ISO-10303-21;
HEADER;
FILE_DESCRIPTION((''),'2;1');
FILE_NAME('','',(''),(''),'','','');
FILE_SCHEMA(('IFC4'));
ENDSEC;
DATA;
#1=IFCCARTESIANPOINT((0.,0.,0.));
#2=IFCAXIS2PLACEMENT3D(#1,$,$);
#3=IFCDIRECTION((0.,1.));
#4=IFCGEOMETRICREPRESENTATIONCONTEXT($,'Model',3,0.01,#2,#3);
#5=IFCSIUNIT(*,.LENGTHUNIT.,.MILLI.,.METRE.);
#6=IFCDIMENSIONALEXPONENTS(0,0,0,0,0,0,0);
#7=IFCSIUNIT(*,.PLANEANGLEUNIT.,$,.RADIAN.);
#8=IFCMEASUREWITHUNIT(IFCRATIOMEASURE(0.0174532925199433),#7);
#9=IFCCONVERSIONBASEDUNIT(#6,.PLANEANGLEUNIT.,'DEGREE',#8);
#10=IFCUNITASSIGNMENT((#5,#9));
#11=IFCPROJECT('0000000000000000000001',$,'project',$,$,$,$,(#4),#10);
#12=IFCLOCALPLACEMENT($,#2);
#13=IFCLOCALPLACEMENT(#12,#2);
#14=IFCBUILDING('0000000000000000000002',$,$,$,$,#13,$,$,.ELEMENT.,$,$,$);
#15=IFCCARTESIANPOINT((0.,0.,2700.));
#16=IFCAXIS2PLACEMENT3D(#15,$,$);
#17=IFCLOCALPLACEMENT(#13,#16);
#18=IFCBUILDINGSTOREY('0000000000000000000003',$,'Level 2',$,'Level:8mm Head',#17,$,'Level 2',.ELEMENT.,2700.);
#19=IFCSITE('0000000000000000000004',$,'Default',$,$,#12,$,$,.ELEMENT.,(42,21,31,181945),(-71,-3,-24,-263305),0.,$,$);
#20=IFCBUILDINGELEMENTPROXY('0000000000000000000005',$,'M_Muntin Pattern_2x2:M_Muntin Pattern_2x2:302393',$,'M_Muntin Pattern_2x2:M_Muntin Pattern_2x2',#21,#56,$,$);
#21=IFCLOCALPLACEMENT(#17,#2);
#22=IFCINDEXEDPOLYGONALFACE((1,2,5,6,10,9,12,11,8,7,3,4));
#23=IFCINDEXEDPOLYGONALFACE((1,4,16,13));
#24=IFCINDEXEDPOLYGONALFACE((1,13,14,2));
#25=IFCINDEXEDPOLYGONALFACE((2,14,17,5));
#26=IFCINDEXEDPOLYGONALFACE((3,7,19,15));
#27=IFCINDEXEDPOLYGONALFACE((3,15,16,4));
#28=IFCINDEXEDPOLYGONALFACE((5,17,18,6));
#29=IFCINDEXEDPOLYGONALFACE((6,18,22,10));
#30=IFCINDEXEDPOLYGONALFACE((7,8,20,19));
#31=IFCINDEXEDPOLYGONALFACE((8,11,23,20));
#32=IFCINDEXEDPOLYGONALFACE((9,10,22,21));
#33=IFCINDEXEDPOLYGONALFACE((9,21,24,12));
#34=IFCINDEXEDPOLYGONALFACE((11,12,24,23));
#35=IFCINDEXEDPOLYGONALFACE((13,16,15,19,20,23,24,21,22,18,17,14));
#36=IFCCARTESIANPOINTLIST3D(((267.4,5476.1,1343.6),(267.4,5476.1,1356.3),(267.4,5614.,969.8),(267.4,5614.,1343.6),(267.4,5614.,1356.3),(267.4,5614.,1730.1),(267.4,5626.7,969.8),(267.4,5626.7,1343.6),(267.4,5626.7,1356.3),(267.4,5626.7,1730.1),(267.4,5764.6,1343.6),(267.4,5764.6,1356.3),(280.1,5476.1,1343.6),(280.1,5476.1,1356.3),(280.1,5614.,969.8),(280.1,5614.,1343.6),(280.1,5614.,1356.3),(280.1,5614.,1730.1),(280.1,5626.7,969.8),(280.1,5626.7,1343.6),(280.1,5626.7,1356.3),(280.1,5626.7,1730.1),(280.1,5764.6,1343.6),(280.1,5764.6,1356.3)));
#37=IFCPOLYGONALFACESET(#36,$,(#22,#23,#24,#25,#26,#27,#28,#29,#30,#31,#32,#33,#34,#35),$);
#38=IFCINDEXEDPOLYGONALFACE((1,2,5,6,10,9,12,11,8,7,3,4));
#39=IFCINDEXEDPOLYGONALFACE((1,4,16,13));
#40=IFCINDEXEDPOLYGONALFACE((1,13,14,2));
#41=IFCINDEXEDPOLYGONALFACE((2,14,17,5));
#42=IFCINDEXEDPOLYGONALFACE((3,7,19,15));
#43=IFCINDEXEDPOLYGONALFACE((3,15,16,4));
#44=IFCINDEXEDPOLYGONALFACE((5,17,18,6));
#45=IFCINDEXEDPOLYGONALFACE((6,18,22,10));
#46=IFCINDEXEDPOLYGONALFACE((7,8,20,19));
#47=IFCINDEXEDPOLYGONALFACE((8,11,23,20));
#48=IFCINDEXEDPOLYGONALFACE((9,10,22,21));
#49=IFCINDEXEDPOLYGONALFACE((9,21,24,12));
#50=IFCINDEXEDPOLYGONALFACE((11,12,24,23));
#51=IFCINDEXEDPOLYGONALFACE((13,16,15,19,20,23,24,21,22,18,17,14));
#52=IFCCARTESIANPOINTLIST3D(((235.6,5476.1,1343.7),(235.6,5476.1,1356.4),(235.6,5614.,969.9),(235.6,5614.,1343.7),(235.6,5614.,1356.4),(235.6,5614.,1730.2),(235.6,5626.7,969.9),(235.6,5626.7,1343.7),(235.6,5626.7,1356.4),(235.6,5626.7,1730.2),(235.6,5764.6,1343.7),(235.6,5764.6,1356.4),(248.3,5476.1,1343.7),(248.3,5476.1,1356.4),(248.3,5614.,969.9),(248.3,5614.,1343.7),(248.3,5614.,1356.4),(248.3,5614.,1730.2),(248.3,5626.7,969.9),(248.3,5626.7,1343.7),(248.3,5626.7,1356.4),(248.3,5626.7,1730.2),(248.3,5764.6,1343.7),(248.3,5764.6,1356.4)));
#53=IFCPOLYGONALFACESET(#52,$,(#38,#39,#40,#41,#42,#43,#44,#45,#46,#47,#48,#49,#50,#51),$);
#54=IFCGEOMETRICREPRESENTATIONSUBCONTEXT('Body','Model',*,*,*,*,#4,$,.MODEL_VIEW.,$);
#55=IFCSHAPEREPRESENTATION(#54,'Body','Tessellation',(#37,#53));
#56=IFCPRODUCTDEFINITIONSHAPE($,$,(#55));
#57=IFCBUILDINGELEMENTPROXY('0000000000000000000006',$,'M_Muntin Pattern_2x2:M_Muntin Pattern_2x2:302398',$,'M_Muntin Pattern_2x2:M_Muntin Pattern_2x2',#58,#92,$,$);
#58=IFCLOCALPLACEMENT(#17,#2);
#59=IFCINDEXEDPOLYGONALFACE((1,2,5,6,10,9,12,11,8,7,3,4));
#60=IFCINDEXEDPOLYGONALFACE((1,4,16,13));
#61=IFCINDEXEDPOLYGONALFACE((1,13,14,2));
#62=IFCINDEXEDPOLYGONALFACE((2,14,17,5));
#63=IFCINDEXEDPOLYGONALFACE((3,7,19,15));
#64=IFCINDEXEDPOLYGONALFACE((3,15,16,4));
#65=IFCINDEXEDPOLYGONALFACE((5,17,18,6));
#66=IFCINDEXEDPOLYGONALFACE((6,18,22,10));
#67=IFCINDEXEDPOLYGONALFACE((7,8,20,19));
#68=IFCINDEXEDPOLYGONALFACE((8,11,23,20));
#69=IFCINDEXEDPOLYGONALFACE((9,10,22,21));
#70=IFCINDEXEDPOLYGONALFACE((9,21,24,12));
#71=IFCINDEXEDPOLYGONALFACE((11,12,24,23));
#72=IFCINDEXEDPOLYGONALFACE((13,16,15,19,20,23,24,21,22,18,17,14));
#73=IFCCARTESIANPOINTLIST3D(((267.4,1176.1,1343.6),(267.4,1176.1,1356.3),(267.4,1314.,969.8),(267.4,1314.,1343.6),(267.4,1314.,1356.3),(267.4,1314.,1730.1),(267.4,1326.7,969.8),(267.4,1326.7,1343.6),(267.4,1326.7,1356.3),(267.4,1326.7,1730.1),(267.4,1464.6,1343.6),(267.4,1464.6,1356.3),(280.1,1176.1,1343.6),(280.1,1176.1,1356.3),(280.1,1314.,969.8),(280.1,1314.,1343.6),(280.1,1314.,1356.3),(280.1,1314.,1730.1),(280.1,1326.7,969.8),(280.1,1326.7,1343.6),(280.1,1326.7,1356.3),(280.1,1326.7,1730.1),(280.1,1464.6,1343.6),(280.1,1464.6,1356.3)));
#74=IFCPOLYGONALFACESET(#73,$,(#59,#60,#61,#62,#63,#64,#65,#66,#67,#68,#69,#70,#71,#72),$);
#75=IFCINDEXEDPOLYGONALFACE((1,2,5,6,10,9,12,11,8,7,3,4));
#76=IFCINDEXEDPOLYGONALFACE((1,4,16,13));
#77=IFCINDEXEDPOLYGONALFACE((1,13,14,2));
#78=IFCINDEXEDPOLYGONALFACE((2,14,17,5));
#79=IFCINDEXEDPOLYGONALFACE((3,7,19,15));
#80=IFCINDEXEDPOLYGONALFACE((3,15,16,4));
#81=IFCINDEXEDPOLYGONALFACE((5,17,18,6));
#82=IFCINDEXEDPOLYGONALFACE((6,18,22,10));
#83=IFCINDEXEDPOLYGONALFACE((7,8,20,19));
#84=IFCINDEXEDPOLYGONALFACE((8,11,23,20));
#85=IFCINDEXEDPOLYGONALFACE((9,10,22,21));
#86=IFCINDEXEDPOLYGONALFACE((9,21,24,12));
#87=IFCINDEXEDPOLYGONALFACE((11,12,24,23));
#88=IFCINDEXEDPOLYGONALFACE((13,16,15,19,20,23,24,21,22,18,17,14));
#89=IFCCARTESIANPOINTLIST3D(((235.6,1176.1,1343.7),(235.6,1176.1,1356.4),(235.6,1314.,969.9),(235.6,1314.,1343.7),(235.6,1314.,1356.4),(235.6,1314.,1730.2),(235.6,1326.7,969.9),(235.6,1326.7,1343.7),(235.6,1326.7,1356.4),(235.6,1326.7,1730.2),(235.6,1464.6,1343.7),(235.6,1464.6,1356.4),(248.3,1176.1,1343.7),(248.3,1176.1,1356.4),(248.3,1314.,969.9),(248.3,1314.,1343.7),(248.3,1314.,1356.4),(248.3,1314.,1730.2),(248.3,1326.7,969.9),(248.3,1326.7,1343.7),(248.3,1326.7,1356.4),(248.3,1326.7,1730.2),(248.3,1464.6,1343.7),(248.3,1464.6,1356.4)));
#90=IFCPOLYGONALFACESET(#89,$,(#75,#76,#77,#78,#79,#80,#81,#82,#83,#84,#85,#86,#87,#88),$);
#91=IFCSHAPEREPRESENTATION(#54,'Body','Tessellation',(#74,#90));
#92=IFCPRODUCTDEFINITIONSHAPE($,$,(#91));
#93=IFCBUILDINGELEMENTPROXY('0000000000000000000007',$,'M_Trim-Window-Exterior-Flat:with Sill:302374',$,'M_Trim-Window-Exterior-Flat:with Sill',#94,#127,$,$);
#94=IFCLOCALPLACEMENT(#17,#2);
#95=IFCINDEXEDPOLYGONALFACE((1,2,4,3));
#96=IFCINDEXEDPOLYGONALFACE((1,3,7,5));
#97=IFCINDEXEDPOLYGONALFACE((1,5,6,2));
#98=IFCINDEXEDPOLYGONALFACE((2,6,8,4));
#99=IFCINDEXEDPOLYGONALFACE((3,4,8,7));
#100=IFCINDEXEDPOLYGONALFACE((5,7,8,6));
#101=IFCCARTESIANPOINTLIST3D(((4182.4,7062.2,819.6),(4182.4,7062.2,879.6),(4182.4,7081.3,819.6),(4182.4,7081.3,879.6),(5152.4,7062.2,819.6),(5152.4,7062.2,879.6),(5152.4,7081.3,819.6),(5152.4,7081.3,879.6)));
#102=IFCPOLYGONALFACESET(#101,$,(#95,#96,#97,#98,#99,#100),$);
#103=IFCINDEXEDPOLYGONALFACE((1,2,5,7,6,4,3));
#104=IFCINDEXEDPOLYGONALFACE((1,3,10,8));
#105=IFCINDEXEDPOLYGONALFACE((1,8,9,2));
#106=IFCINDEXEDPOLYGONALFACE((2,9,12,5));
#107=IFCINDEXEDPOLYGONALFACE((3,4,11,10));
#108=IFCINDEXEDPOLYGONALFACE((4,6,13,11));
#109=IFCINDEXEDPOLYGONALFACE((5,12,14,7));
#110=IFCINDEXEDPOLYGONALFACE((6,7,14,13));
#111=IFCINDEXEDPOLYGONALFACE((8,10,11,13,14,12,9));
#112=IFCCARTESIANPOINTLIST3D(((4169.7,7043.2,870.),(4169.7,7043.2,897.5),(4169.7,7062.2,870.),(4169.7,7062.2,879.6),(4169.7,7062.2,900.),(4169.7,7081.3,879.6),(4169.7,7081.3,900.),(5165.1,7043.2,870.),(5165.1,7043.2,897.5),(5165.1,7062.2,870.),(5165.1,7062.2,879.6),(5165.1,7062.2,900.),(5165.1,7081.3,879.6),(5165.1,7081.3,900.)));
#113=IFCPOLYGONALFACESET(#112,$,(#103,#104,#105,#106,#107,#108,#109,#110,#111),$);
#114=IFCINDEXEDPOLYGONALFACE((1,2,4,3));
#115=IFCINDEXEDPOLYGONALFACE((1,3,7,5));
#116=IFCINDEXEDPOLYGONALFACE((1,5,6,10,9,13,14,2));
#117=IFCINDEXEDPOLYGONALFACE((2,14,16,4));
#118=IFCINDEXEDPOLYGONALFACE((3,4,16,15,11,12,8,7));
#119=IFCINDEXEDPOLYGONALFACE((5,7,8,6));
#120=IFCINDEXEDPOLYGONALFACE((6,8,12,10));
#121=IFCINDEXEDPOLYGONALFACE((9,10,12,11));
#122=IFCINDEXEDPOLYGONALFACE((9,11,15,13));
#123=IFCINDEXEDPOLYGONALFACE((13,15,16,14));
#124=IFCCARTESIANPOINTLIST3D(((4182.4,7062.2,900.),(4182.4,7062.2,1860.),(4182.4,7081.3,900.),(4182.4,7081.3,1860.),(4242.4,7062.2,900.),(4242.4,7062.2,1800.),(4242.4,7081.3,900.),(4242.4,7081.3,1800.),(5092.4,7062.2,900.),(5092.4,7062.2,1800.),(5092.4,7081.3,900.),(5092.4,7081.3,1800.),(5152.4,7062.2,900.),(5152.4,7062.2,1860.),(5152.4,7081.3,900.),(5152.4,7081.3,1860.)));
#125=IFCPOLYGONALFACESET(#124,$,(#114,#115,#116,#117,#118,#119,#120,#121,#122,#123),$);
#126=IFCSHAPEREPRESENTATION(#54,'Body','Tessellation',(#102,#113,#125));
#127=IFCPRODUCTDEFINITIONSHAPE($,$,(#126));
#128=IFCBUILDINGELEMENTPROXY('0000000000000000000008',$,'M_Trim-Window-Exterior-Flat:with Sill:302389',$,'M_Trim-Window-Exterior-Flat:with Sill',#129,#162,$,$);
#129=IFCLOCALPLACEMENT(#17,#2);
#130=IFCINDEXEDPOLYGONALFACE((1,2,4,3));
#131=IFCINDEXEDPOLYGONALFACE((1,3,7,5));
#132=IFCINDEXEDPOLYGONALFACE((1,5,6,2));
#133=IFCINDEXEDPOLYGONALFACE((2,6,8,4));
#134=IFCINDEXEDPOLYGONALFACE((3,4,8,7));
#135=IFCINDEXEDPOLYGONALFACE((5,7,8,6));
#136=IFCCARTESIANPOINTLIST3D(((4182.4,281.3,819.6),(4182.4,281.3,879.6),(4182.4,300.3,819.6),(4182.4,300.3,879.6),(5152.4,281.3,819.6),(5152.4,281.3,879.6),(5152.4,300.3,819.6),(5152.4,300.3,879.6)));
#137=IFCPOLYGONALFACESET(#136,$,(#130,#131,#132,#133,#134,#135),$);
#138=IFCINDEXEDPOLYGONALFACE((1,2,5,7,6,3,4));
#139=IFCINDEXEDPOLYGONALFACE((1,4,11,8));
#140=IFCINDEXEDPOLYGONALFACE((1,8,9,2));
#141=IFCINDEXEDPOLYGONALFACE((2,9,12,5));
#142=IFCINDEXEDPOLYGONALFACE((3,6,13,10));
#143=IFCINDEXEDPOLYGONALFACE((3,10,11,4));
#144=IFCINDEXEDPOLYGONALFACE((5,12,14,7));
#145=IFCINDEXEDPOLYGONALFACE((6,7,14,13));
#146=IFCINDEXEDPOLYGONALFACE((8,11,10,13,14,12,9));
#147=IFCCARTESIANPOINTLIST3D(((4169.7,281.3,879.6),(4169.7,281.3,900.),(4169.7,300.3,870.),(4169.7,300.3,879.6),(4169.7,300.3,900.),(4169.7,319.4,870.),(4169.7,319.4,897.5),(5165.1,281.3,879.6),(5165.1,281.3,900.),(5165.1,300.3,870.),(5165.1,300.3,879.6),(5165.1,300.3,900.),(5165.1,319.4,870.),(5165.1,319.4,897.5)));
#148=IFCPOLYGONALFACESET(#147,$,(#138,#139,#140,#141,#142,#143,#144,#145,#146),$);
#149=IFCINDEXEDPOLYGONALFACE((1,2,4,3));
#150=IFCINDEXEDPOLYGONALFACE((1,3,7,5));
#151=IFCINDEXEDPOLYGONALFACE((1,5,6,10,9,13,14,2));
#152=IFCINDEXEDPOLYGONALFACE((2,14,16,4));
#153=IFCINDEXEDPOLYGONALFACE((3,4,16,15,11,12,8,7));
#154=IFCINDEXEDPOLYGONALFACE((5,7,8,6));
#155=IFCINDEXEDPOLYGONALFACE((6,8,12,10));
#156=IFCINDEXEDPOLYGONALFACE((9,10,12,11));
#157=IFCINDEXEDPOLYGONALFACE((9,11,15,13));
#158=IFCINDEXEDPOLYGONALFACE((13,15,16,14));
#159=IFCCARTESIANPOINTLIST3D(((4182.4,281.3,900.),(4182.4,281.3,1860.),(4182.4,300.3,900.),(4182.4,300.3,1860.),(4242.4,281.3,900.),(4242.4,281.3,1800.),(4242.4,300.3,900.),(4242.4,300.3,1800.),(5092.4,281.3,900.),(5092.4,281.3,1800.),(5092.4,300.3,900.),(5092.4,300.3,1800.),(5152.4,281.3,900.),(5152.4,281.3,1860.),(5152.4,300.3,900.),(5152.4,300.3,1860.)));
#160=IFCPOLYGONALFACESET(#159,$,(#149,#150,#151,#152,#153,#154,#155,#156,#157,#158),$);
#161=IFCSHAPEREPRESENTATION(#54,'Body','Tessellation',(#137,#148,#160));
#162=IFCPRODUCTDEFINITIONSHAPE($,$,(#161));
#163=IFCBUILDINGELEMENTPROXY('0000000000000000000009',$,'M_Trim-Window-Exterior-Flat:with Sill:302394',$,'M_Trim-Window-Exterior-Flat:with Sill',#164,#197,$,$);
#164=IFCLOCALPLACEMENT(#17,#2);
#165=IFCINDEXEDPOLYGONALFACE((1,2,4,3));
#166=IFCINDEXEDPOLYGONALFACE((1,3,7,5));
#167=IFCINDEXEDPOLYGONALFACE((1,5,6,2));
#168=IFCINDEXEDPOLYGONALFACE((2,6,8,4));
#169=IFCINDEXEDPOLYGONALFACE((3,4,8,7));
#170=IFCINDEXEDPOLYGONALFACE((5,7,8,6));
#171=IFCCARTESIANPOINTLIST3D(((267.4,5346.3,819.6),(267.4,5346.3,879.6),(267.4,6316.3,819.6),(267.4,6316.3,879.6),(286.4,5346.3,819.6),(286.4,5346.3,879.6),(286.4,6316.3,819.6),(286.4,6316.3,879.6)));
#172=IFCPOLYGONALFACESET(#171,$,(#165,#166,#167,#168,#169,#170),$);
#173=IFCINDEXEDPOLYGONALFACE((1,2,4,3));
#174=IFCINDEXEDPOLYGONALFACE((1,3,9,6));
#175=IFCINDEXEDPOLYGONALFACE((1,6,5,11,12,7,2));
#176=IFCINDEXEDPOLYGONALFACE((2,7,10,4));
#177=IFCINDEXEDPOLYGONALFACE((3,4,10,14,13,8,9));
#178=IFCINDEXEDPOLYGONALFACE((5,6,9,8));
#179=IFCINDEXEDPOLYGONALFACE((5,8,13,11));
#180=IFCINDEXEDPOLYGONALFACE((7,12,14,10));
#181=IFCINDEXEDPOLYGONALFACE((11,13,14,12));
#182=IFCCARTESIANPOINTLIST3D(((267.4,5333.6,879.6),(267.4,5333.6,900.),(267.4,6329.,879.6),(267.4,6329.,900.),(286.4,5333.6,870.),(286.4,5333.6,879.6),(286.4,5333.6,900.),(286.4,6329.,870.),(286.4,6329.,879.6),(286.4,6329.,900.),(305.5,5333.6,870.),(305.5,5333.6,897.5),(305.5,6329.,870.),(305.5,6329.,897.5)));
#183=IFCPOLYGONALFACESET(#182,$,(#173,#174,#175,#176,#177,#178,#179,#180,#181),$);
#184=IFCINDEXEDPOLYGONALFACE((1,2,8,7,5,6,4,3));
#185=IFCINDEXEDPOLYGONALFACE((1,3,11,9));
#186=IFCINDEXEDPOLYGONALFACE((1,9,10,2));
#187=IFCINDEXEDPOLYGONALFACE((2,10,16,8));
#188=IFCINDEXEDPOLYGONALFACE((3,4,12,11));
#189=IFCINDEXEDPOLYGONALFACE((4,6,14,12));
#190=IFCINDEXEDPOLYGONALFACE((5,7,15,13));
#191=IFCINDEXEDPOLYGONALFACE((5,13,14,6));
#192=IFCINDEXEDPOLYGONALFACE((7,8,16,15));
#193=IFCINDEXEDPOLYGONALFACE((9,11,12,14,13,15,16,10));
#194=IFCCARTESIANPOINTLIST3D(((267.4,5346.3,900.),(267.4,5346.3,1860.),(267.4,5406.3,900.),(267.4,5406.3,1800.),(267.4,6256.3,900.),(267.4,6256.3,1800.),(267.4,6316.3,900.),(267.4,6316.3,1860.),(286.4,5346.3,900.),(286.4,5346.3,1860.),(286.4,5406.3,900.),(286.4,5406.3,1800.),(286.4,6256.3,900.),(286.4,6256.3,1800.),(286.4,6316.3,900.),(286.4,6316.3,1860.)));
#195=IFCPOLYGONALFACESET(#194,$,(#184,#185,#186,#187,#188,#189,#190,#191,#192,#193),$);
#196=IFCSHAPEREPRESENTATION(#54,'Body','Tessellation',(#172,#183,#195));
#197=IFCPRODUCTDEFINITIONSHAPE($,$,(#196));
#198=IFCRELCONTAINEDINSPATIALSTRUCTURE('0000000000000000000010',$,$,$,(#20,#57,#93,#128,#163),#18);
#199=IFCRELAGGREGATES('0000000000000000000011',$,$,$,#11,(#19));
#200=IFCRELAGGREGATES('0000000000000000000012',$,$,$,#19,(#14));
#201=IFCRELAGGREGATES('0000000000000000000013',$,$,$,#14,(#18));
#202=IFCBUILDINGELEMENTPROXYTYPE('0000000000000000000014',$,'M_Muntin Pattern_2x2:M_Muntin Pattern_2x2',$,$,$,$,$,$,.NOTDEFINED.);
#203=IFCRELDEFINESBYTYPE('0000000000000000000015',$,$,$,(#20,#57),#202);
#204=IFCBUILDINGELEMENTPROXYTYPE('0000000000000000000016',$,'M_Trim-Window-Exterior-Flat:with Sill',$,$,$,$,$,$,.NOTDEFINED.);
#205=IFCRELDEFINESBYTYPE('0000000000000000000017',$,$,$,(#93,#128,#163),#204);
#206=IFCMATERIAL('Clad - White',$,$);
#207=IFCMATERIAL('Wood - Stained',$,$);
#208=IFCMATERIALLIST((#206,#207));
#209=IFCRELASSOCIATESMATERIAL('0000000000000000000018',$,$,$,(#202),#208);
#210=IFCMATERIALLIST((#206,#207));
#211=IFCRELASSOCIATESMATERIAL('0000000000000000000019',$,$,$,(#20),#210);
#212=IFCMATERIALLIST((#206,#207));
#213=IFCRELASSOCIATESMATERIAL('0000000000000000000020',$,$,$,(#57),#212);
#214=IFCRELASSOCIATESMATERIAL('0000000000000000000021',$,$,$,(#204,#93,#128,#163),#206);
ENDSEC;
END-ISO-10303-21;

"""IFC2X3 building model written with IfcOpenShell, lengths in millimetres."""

from ifc_helpers import new_model, entity, si_unit, converted_unit, direction, frame, frame_2d, origin, place, context, subcontext, project, spatial, polyline, rectangle, outline, extrude, source, transform, mapped, material, material_list, type_object, type_shapes, element, save


model = new_model("IFC2X3")

# Units and contexts
model_context = context("Model", 3, precision=0.01, world=origin(), true_north=direction((0.0, 1.0)))
body_context = subcontext(model_context, "Body", "Model", "MODEL_VIEW")
ifc_project = project(units=[si_unit("LENGTHUNIT", "METRE", prefix="MILLI"), converted_unit("PLANEANGLEUNIT", "DEGREE", entity("IfcRatioMeasure", 0.0174532925199433), si_unit("PLANEANGLEUNIT", "RADIAN"), dimensions=[0, 0, 0, 0, 0, 0, 0])], contexts=[model_context])

# Site, building, storey
site_placement = place(None, origin())
site = spatial("IfcSite", under=ifc_project, at=site_placement, Name="Default", CompositionType="ELEMENT", RefLatitude=(42, 21, 31, 181945), RefLongitude=(-71, -3, -24, -263305), RefElevation=0.0)
building_placement = place(site_placement, origin())
building = spatial("IfcBuilding", under=site, at=building_placement, CompositionType="ELEMENT")
storey_placement = place(building_placement, frame((0.0, 0.0, 2700.0)))
storey = spatial("IfcBuildingStorey", under=building, at=storey_placement, Name="Level 2", ObjectType="Level:8mm Head", LongName="Level 2", CompositionType="ELEMENT", Elevation=2700.0)

# Building element proxies
ifc_material_1 = material(Name="Clad - White")
ifc_material_2 = material(Name="Wood - Stained")
ifc_material_list_1 = material_list([ifc_material_1, ifc_material_2])
building_element_proxy_type_1 = type_object("IfcBuildingElementProxyType", Name="M_Muntin Pattern_2x2:M_Muntin Pattern_2x2", PredefinedType="NOTDEFINED", material=ifc_material_list_1)
shared_shape_1 = source(origin(), body_context, "Body", "SweptSolid", [
    extrude(outline(polyline([(6.4, -6.4), (380.1, -6.4), (380.1, 6.3), (6.4, 6.3), (6.4, 144.2), (-6.3, 144.2), (-6.3, 6.3), (-380.2, 6.3), (-380.2, -6.4), (-6.3, -6.4), (-6.3, -144.2), (6.4, -144.2), (6.4, -6.4)])), frame((0.0, -22.2, 380.1), z_axis=(0.0, 1.0, 0.0), x_axis=(0.0, 0.0, 1.0)), (0.0, 0.0, 1.0), 12.7),
    extrude(outline(polyline([(6.4, -6.4), (380.2, -6.4), (380.2, 6.3), (6.4, 6.3), (6.4, 144.2), (-6.3, 144.2), (-6.3, 6.3), (-380.2, 6.3), (-380.2, -6.4), (-6.3, -6.4), (-6.3, -144.2), (6.4, -144.2), (6.4, -6.4)])), frame((0.0, 9.5, 380.2), z_axis=(0.0, 1.0, 0.0), x_axis=(0.0, 0.0, 1.0)), (0.0, 0.0, 1.0), 12.7),
])
type_shapes(building_element_proxy_type_1, [shared_shape_1])
ifc_material_list_2 = material_list([ifc_material_1, ifc_material_2])
proxy_1_placement = place(storey_placement, frame((257.9, 5620.4, 969.9), z_axis=(0.0, 0.0, 1.0), x_axis=(0.0, 1.0, 0.0)))
element("IfcBuildingElementProxy", 1, at=proxy_1_placement, inside=storey, type_object=building_element_proxy_type_1, material=ifc_material_list_2, Name="M_Muntin Pattern_2x2:M_Muntin Pattern_2x2:302393", ObjectType="M_Muntin Pattern_2x2:M_Muntin Pattern_2x2", context=body_context, shape_type="MappedRepresentation", body=[
    mapped(shared_shape_1, transform((0.0, 0.0, 0.0), scale=1.0)),
])
ifc_material_list_3 = material_list([ifc_material_1, ifc_material_2])
proxy_2_placement = place(storey_placement, frame((257.9, 1320.4, 969.9), z_axis=(0.0, 0.0, 1.0), x_axis=(0.0, 1.0, 0.0)))
element("IfcBuildingElementProxy", 2, at=proxy_2_placement, inside=storey, type_object=building_element_proxy_type_1, material=ifc_material_list_3, Name="M_Muntin Pattern_2x2:M_Muntin Pattern_2x2:302398", ObjectType="M_Muntin Pattern_2x2:M_Muntin Pattern_2x2", context=body_context, shape_type="MappedRepresentation", body=[
    mapped(shared_shape_1, transform((0.0, 0.0, 0.0), scale=1.0)),
])
building_element_proxy_type_2 = type_object("IfcBuildingElementProxyType", Name="M_Trim-Window-Exterior-Flat:with Sill", PredefinedType="NOTDEFINED", material=ifc_material_1)
shared_shape_2 = source(origin(), body_context, "Body", "SweptSolid", [
    extrude(rectangle(XDim=970.0, YDim=60.0, at=frame_2d((0.0, 0.0), x_axis=(1.0, 0.0))), frame((0.0, -950.4, 0.0), z_axis=(0.0, 0.0, 1.0), x_axis=(-1.0, 0.0, 0.0)), (0.0, 0.0, 1.0), 19.1),
    extrude(outline(polyline([(-19.0, -15.2), (0.0, -15.2), (0.0, -5.7), (19.0, -5.7), (19.0, 14.8), (0.0, 14.8), (-19.0, 12.3), (-19.0, -15.2)])), frame((-497.7, -914.8, 19.0), z_axis=(1.0, 0.0, 0.0), x_axis=(0.0, 0.0, -1.0)), (0.0, 0.0, 1.0), 995.4),
    extrude(outline(polyline([(-495.0, -485.0), (465.0, -485.0), (465.0, -425.0), (-435.0, -425.0), (-435.0, 425.0), (465.0, 425.0), (465.0, 485.0), (-495.0, 485.0), (-495.0, -485.0)])), frame((0.0, -435.0, 0.0), z_axis=(0.0, 0.0, 1.0), x_axis=(0.0, -1.0, 0.0)), (0.0, 0.0, 1.0), 19.1),
])
type_shapes(building_element_proxy_type_2, [shared_shape_2])
for number, where, z_axis, x_axis, name in (
    (3, (4667.4, 7081.3, 1800.0), (0.0, -1.0, 0.0), (1.0, 0.0, 0.0), "M_Trim-Window-Exterior-Flat:with Sill:302374"),
    (4, (4667.4, 281.3, 1800.0), (0.0, 1.0, 0.0), (-1.0, 0.0, 0.0), "M_Trim-Window-Exterior-Flat:with Sill:302389"),
    (5, (267.4, 5831.3, 1800.0), (1.0, 0.0, 0.0), (0.0, 1.0, 0.0), "M_Trim-Window-Exterior-Flat:with Sill:302394"),
):
    element("IfcBuildingElementProxy", number, at=place(storey_placement, frame(where, z_axis=z_axis, x_axis=x_axis)), inside=storey, type_object=building_element_proxy_type_2, material=ifc_material_1, Name=name, ObjectType="M_Trim-Window-Exterior-Flat:with Sill", context=body_context, shape_type="MappedRepresentation", body=[
        mapped(shared_shape_2, transform((0.0, 0.0, 0.0), scale=1.0)),
    ])

save(model, "model.ifc")
